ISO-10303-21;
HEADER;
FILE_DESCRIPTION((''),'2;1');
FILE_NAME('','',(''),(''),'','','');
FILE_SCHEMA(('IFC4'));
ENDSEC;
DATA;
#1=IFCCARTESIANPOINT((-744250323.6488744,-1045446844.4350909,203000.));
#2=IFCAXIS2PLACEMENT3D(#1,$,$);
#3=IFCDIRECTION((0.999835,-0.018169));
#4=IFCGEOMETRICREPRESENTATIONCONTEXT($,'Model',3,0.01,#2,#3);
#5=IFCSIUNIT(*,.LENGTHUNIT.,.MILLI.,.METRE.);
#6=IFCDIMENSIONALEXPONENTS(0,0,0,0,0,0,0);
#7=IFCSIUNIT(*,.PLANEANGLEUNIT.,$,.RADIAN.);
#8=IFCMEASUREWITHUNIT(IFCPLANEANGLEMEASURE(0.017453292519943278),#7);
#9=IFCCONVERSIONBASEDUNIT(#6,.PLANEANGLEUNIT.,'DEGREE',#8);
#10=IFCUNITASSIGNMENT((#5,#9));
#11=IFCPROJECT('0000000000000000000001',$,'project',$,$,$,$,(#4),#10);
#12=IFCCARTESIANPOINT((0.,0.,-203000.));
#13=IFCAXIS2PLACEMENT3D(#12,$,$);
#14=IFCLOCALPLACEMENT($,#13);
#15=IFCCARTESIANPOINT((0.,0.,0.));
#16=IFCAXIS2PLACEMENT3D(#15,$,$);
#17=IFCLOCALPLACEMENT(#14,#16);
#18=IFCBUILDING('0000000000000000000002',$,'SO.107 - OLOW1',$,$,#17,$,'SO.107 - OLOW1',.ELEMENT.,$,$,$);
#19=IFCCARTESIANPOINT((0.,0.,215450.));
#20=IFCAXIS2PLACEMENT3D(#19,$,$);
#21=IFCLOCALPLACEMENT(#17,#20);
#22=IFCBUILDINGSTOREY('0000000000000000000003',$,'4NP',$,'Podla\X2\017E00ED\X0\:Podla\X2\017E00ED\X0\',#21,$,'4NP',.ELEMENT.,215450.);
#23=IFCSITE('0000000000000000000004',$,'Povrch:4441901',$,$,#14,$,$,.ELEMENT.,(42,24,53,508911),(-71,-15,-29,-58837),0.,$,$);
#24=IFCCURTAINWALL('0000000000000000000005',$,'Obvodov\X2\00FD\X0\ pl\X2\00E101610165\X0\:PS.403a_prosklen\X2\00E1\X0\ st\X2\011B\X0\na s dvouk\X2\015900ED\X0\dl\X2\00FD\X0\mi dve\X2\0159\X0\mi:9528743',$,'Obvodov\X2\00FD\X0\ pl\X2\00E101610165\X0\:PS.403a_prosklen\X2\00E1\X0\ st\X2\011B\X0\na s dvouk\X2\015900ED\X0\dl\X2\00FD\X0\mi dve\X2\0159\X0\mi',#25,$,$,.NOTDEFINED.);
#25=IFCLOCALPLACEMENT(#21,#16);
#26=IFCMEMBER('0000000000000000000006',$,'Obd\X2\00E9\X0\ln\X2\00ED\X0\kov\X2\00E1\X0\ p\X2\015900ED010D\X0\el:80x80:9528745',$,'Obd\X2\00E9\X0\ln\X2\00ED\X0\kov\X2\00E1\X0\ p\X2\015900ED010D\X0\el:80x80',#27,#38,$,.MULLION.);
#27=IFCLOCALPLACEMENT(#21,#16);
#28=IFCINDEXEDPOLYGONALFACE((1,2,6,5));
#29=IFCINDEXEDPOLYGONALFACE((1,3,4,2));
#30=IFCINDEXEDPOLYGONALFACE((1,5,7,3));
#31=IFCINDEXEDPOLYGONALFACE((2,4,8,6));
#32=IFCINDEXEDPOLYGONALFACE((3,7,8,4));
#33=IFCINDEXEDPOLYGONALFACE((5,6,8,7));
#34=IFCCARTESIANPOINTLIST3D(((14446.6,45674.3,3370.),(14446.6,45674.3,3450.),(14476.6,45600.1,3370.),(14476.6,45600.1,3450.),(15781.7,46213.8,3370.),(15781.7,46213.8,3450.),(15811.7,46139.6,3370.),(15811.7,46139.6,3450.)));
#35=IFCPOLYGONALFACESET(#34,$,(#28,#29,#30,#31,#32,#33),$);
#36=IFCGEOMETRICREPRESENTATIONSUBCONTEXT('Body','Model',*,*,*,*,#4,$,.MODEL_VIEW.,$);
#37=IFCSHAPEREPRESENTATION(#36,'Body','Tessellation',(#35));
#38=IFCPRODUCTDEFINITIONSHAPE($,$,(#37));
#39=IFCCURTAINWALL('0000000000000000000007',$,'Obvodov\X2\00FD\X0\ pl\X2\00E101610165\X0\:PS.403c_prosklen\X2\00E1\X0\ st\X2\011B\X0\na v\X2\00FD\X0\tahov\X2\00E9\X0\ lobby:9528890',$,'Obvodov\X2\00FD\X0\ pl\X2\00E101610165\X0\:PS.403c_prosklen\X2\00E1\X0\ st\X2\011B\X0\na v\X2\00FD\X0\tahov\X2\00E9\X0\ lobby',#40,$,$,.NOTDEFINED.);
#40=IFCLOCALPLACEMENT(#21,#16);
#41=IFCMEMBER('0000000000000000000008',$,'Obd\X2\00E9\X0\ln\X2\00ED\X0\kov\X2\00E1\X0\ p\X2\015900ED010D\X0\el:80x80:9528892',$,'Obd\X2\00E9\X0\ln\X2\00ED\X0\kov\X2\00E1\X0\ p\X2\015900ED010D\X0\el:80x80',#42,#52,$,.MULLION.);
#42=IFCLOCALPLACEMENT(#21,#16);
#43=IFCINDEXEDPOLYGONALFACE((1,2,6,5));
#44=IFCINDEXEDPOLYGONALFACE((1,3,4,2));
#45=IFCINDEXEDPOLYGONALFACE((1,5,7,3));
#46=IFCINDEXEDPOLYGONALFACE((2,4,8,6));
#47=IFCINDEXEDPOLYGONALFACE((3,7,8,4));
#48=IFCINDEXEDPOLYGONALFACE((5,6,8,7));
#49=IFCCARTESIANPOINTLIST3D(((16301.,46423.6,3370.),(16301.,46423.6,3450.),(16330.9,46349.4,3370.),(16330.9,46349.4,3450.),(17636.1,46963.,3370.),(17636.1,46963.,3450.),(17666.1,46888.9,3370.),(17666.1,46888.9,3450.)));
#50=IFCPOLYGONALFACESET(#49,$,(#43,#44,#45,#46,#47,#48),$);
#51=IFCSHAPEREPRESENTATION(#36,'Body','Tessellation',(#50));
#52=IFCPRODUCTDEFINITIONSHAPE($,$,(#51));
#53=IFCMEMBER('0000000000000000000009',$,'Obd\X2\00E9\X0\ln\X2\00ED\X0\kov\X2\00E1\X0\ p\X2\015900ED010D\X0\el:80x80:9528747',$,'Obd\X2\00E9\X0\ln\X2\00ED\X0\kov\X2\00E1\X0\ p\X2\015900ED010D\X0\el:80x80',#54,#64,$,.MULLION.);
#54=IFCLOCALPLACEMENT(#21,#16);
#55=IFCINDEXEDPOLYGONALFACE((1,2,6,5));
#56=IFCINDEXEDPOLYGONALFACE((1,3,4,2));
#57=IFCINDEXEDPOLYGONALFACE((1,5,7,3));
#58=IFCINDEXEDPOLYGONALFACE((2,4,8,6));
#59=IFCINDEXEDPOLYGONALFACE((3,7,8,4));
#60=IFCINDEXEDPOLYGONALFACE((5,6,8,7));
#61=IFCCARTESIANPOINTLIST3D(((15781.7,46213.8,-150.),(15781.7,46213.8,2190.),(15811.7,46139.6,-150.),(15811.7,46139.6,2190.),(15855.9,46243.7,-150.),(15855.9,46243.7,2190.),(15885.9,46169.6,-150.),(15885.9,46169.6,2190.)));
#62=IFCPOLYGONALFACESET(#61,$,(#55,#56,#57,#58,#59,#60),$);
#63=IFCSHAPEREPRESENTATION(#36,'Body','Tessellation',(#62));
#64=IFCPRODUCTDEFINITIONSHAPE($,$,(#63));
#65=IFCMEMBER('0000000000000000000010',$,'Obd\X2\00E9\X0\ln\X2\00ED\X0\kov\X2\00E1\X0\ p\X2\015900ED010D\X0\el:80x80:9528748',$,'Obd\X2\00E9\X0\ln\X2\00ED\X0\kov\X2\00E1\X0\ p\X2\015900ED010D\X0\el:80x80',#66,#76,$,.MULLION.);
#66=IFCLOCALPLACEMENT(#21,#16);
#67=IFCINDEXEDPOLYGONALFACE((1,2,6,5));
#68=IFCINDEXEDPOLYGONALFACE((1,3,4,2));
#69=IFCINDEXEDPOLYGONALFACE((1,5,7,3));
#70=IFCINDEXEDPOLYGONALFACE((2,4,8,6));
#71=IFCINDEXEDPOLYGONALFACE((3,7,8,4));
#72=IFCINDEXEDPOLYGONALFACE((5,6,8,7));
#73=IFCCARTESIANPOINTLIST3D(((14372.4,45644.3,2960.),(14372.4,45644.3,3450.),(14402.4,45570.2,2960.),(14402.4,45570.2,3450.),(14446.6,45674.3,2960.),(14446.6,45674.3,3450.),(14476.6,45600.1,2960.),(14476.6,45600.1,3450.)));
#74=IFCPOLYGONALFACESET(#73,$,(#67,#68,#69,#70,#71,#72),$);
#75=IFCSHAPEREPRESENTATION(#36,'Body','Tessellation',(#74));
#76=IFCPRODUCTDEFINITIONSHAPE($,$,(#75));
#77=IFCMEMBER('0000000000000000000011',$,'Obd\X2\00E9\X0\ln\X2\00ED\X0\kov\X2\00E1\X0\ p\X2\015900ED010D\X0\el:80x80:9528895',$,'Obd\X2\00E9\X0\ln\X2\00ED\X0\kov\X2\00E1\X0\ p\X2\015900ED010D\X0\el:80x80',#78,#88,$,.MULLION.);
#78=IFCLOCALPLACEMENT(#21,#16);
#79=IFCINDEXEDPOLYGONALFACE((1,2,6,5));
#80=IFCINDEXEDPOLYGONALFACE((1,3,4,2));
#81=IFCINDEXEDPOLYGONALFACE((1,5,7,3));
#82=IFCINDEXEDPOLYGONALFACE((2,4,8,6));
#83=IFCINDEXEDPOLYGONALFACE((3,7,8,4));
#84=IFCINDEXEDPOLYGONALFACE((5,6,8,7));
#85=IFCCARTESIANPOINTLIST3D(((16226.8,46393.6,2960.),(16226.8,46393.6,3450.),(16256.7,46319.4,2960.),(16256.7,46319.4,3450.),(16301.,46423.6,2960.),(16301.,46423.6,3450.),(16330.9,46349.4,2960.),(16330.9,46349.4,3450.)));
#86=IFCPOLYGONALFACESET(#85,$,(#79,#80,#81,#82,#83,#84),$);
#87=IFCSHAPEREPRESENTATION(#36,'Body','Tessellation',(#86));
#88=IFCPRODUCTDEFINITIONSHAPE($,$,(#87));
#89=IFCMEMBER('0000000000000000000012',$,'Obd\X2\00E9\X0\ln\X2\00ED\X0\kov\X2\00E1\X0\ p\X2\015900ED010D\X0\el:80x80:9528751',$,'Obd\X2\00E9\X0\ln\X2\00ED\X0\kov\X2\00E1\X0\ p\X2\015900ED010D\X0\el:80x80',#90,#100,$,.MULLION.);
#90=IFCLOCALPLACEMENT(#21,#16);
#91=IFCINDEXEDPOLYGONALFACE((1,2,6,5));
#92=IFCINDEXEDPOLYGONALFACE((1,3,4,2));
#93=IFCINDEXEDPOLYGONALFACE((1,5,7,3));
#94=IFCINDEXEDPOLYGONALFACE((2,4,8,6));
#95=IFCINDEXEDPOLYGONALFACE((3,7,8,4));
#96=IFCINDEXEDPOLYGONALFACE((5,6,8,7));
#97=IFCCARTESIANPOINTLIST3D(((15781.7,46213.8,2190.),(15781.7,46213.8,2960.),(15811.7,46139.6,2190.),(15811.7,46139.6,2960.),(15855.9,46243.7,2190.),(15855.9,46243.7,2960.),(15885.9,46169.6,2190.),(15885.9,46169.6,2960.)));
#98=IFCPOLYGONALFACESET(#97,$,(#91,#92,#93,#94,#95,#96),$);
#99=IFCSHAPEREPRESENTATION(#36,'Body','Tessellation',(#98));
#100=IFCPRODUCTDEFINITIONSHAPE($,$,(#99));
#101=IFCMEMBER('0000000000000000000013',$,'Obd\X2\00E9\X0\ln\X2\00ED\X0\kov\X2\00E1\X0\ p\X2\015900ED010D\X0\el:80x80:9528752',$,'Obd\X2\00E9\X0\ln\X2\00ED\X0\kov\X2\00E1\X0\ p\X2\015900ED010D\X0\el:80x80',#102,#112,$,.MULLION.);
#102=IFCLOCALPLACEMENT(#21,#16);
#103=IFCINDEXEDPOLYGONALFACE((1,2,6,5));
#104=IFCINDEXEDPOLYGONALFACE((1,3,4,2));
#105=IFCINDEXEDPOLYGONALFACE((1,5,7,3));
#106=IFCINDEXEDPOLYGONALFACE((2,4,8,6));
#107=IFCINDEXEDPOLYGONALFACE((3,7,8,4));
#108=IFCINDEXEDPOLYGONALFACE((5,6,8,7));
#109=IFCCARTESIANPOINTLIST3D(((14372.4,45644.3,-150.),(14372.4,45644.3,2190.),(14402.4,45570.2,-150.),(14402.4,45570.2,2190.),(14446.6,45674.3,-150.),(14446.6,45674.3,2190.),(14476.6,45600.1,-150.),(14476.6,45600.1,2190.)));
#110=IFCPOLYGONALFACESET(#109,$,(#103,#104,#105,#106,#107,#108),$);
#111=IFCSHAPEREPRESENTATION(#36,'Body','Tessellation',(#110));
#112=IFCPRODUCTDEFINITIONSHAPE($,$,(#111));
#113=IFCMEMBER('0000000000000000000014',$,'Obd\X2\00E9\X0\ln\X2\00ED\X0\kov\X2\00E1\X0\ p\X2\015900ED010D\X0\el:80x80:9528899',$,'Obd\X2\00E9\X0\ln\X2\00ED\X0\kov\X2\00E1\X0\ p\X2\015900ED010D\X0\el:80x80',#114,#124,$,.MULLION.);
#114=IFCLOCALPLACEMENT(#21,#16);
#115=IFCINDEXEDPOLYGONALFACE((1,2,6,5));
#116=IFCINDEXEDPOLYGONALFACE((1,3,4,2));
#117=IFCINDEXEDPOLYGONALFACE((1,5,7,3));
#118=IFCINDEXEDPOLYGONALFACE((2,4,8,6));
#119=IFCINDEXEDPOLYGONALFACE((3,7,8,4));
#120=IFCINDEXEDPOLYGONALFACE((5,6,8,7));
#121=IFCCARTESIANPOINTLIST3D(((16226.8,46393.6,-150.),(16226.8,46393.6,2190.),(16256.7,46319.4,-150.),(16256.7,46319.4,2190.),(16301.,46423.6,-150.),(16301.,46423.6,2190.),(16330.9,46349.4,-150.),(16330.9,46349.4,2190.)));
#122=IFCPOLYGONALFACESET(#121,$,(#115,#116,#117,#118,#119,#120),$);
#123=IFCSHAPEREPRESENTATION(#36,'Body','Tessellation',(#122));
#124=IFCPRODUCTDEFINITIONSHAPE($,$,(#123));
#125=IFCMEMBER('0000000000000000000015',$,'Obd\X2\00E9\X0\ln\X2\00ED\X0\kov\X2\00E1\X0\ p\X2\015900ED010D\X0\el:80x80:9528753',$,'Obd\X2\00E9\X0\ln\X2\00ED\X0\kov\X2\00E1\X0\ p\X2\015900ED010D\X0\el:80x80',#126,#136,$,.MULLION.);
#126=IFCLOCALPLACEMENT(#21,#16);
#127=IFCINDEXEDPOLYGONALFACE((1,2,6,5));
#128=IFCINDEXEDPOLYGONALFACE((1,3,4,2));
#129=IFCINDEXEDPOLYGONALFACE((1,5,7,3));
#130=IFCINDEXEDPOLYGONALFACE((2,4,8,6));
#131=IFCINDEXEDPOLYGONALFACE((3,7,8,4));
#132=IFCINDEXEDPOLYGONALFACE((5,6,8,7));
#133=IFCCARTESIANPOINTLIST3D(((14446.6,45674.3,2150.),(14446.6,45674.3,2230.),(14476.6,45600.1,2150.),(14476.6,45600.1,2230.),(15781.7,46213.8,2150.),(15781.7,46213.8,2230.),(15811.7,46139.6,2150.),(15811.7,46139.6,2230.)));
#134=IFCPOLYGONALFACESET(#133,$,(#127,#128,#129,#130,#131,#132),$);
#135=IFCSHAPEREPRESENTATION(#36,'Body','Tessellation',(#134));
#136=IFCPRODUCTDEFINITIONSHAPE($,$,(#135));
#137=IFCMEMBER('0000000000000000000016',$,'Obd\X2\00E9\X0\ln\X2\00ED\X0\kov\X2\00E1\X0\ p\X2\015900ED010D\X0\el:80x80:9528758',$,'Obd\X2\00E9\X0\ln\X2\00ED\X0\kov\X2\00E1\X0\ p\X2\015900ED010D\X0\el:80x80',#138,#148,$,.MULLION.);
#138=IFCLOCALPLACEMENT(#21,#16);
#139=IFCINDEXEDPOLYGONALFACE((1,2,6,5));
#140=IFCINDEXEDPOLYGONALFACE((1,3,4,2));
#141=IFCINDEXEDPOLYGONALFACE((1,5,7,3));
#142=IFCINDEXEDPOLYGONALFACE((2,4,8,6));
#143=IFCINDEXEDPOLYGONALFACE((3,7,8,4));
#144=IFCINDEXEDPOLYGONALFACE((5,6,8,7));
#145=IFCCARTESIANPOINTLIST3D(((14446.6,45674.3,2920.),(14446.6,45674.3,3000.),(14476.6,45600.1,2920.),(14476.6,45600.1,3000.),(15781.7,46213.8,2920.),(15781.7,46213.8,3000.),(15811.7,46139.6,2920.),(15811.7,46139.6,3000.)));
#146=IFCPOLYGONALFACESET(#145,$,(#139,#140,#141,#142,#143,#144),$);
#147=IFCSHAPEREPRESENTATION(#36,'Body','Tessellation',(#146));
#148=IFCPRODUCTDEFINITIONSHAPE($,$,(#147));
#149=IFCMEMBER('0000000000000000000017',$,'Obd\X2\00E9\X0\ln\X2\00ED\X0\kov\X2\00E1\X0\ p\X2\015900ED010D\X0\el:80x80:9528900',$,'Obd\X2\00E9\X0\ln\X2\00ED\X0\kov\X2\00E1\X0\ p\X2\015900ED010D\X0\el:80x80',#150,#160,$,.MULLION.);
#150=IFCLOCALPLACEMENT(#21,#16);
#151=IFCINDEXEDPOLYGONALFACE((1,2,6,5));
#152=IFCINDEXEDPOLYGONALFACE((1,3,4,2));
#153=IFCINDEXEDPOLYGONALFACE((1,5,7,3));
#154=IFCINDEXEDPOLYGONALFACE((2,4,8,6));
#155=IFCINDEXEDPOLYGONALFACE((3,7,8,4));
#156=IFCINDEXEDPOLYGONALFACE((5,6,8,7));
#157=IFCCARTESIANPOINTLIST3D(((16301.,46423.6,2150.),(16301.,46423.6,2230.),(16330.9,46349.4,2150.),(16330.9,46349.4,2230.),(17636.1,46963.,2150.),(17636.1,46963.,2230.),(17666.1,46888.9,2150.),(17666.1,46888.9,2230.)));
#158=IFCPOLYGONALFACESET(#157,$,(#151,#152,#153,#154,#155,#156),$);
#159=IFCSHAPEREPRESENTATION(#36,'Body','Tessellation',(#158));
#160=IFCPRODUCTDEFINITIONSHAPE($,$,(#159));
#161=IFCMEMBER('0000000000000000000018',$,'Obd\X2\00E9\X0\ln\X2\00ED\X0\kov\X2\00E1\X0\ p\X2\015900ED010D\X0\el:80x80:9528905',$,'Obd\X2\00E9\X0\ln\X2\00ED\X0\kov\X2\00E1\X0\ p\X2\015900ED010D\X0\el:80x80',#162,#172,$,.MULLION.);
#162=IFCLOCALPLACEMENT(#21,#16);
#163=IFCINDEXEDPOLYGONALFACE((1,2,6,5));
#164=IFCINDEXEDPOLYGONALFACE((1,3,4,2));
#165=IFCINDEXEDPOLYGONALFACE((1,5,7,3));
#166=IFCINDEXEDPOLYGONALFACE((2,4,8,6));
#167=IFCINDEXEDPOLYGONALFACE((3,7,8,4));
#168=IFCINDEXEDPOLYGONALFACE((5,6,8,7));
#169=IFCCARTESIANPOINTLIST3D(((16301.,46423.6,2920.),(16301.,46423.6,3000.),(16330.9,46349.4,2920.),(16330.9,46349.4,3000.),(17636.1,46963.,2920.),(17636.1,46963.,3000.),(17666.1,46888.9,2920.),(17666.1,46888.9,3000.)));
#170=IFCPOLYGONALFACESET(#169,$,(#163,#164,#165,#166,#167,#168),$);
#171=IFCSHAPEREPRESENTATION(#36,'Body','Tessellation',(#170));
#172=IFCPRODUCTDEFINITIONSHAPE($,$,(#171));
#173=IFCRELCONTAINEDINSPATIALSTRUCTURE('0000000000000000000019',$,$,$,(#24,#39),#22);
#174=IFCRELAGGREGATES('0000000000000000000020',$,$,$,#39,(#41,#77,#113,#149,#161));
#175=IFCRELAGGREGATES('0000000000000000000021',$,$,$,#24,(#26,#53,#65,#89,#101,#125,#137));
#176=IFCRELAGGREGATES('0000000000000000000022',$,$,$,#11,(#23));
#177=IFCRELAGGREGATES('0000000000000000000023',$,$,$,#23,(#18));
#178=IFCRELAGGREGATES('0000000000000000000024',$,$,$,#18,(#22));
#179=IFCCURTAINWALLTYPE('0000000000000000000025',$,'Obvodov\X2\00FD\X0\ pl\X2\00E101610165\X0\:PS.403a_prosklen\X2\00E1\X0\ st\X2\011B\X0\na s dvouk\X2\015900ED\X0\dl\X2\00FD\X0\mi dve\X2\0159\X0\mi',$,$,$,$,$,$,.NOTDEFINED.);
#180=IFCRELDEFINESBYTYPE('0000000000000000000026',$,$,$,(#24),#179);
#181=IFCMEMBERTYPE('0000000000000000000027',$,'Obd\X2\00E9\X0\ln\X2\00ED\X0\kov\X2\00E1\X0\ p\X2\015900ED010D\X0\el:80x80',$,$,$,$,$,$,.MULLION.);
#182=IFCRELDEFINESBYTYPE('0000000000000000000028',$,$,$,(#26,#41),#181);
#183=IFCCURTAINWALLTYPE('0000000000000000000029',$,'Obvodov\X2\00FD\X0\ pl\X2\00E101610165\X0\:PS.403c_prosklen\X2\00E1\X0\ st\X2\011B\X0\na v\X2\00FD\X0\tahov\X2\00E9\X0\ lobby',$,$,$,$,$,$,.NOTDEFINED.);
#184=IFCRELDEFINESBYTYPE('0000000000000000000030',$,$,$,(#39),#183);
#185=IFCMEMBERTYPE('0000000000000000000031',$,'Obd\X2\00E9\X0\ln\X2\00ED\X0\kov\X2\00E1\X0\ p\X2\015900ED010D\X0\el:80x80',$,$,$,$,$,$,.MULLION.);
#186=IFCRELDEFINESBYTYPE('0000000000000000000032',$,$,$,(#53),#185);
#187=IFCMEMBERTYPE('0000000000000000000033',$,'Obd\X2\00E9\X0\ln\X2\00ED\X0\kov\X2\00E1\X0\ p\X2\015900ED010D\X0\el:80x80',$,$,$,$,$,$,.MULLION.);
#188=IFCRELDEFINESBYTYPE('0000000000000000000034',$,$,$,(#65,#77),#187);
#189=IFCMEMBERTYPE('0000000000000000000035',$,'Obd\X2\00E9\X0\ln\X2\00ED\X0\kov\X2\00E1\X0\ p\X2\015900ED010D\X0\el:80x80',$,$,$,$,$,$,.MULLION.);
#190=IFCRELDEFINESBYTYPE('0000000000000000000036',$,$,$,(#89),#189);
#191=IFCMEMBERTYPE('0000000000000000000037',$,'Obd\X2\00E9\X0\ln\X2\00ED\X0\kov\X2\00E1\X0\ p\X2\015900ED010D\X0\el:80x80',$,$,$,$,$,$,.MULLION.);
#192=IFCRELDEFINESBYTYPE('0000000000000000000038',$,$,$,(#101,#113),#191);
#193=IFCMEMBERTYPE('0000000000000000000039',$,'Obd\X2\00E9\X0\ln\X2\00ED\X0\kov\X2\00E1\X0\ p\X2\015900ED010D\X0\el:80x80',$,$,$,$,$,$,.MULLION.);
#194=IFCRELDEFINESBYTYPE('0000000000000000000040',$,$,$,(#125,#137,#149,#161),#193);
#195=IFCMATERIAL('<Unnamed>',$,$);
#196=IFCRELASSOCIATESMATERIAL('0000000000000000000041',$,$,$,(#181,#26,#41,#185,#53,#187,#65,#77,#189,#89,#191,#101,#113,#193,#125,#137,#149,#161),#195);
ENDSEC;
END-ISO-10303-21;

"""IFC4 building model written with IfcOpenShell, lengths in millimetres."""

from ifc_helpers import new_model, entity, si_unit, converted_unit, direction, frame, origin, place, context, subcontext, project, spatial, indexed_curve, outline, extrude, source, transform, mapped, material, type_object, type_shapes, element, aggregate, save


model = new_model("IFC4")

# Units and contexts
model_context = context("Model", 3, precision=0.01, world=frame((-744250323.6488744, -1045446844.4350909, 203000.0)), true_north=direction((0.999835, -0.018169)))
body_context = subcontext(model_context, "Body", "Model", "MODEL_VIEW")
ifc_project = project(units=[si_unit("LENGTHUNIT", "METRE", prefix="MILLI"), converted_unit("PLANEANGLEUNIT", "DEGREE", entity("IfcPlaneAngleMeasure", 0.017453292519943278), si_unit("PLANEANGLEUNIT", "RADIAN"), dimensions=[0, 0, 0, 0, 0, 0, 0])], contexts=[model_context])

# Site, building, storey
site_placement = place(None, frame((0.0, 0.0, -203000.0)))
site = spatial("IfcSite", under=ifc_project, at=site_placement, Name="Povrch:4441901", CompositionType="ELEMENT", RefLatitude=(42, 24, 53, 508911), RefLongitude=(-71, -15, -29, -58837), RefElevation=0.0)
building_placement = place(site_placement, origin())
building = spatial("IfcBuilding", under=site, at=building_placement, Name="SO.107 - OLOW1", LongName="SO.107 - OLOW1", CompositionType="ELEMENT")
storey_placement = place(building_placement, frame((0.0, 0.0, 215450.0)))
storey = spatial("IfcBuildingStorey", under=building, at=storey_placement, Name="4NP", ObjectType="Podlaží:Podlaží", LongName="4NP", CompositionType="ELEMENT", Elevation=215450.0)

# Curtain walls, members
curtain_wall_type_1 = type_object("IfcCurtainWallType", Name="Obvodový plášť:PS.403a_prosklená stěna s dvoukřídlými dveřmi", PredefinedType="NOTDEFINED")
curtain_wall_1_placement = place(storey_placement, frame((0.0, 0.0, -215450.0)))
curtain_wall_1 = element("IfcCurtainWall", 1, at=curtain_wall_1_placement, inside=storey, type_object=curtain_wall_type_1, Name="Obvodový plášť:PS.403a_prosklená stěna s dvoukřídlými dveřmi:9528743", ObjectType="Obvodový plášť:PS.403a_prosklená stěna s dvoukřídlými dveřmi", PredefinedType="NOTDEFINED")
ifc_material_1 = material(Name="<Unnamed>")
member_type_1 = type_object("IfcMemberType", Name="Obdélníková příčel:80x80", PredefinedType="MULLION", material=ifc_material_1)
shared_shape_1 = source(origin(), body_context, "Body", "SweptSolid", [
    extrude(outline(indexed_curve([(-40.0, -40.0), (40.0, -40.0), (40.0, 40.0), (-40.0, 40.0), (-40.0, -40.0)], self_intersect=False)), frame((-40.0, 0.0, -1440.0), z_axis=(0.0, 0.0, 1.0), x_axis=(-1.0, 0.0, 0.0)), (0.0, 0.0, 1.0), 1440.0),
])
type_shapes(member_type_1, [shared_shape_1])
member_1_placement = place(curtain_wall_1_placement, frame((15796.7, 46176.7, 218900.0), z_axis=(0.927176, 0.374626, 0.0), x_axis=(0.0, 0.0, 1.0)))
member_1 = element("IfcMember", 2, at=member_1_placement, type_object=member_type_1, material=ifc_material_1, Name="Obdélníková příčel:80x80:9528745", ObjectType="Obdélníková příčel:80x80", PredefinedType="MULLION", context=body_context, shape_type="MappedRepresentation", body=[
    mapped(shared_shape_1, transform((0.0, 0.0, 0.0), scale=1.0)),
])
curtain_wall_type_2 = type_object("IfcCurtainWallType", Name="Obvodový plášť:PS.403c_prosklená stěna výtahové lobby", PredefinedType="NOTDEFINED")
curtain_wall_2_placement = place(storey_placement, frame((0.0, 0.0, -215450.0)))
curtain_wall_2 = element("IfcCurtainWall", 3, at=curtain_wall_2_placement, inside=storey, type_object=curtain_wall_type_2, Name="Obvodový plášť:PS.403c_prosklená stěna výtahové lobby:9528890", ObjectType="Obvodový plášť:PS.403c_prosklená stěna výtahové lobby", PredefinedType="NOTDEFINED")
member_2_placement = place(curtain_wall_2_placement, frame((17651.1, 46925.9, 218900.0), z_axis=(0.927176, 0.374626, 0.0), x_axis=(0.0, 0.0, 1.0)))
member_2 = element("IfcMember", 4, at=member_2_placement, type_object=member_type_1, material=ifc_material_1, Name="Obdélníková příčel:80x80:9528892", ObjectType="Obdélníková příčel:80x80", PredefinedType="MULLION", context=body_context, shape_type="MappedRepresentation", body=[
    mapped(shared_shape_1, transform((0.0, 0.0, 0.0), scale=1.0)),
])

# Members
member_type_2 = type_object("IfcMemberType", Name="Obdélníková příčel:80x80", PredefinedType="MULLION", material=ifc_material_1)
shared_shape_2 = source(origin(), body_context, "Body", "SweptSolid", [
    extrude(outline(indexed_curve([(-40.0, -40.0), (40.0, -40.0), (40.0, 40.0), (-40.0, 40.0), (-40.0, -40.0)], self_intersect=False)), frame((-40.0, 0.0, -2340.0), z_axis=(0.0, 0.0, 1.0), x_axis=(-1.0, 0.0, 0.0)), (0.0, 0.0, 1.0), 2340.0),
])
type_shapes(member_type_2, [shared_shape_2])
member_3_placement = place(curtain_wall_1_placement, frame((15870.9, 46206.7, 215300.0), z_axis=(0.0, 0.0, -1.0), x_axis=(0.927176, 0.374626, 0.0)))
member_3 = element("IfcMember", 5, at=member_3_placement, type_object=member_type_2, material=ifc_material_1, Name="Obdélníková příčel:80x80:9528747", ObjectType="Obdélníková příčel:80x80", PredefinedType="MULLION", context=body_context, shape_type="MappedRepresentation", body=[
    mapped(shared_shape_2, transform((0.0, 0.0, 0.0), scale=1.0)),
])
member_type_3 = type_object("IfcMemberType", Name="Obdélníková příčel:80x80", PredefinedType="MULLION", material=ifc_material_1)
shared_shape_3 = source(origin(), body_context, "Body", "SweptSolid", [
    extrude(outline(indexed_curve([(-40.0, -40.0), (40.0, -40.0), (40.0, 40.0), (-40.0, 40.0), (-40.0, -40.0)], self_intersect=False)), frame((-40.0, 0.0, -490.0), z_axis=(0.0, 0.0, 1.0), x_axis=(-1.0, 0.0, 0.0)), (0.0, 0.0, 1.0), 490.0),
])
type_shapes(member_type_3, [shared_shape_3])
member_4_placement = place(curtain_wall_1_placement, frame((14387.4, 45607.3, 218900.0), z_axis=(0.0, 0.0, 1.0), x_axis=(-0.927176, -0.374626, 0.0)))
member_4 = element("IfcMember", 6, at=member_4_placement, type_object=member_type_3, material=ifc_material_1, Name="Obdélníková příčel:80x80:9528748", ObjectType="Obdélníková příčel:80x80", PredefinedType="MULLION", context=body_context, shape_type="MappedRepresentation", body=[
    mapped(shared_shape_3, transform((0.0, 0.0, 0.0), scale=1.0)),
])
member_5_placement = place(curtain_wall_2_placement, frame((16241.8, 46356.5, 218900.0), z_axis=(0.0, 0.0, 1.0), x_axis=(-0.927176, -0.374626, 0.0)))
member_5 = element("IfcMember", 7, at=member_5_placement, type_object=member_type_3, material=ifc_material_1, Name="Obdélníková příčel:80x80:9528895", ObjectType="Obdélníková příčel:80x80", PredefinedType="MULLION", context=body_context, shape_type="MappedRepresentation", body=[
    mapped(shared_shape_3, transform((0.0, 0.0, 0.0), scale=1.0)),
])
member_type_4 = type_object("IfcMemberType", Name="Obdélníková příčel:80x80", PredefinedType="MULLION", material=ifc_material_1)
shared_shape_4 = source(origin(), body_context, "Body", "SweptSolid", [
    extrude(outline(indexed_curve([(-40.0, -40.0), (40.0, -40.0), (40.0, 40.0), (-40.0, 40.0), (-40.0, -40.0)], self_intersect=False)), frame((-40.0, 0.0, -770.0), z_axis=(0.0, 0.0, 1.0), x_axis=(-1.0, 0.0, 0.0)), (0.0, 0.0, 1.0), 770.0),
])
type_shapes(member_type_4, [shared_shape_4])
member_6_placement = place(curtain_wall_1_placement, frame((15870.9, 46206.7, 217640.0), z_axis=(0.0, 0.0, -1.0), x_axis=(0.927176, 0.374626, 0.0)))
member_6 = element("IfcMember", 8, at=member_6_placement, type_object=member_type_4, material=ifc_material_1, Name="Obdélníková příčel:80x80:9528751", ObjectType="Obdélníková příčel:80x80", PredefinedType="MULLION", context=body_context, shape_type="MappedRepresentation", body=[
    mapped(shared_shape_4, transform((0.0, 0.0, 0.0), scale=1.0)),
])
member_type_5 = type_object("IfcMemberType", Name="Obdélníková příčel:80x80", PredefinedType="MULLION", material=ifc_material_1)
shared_shape_5 = source(origin(), body_context, "Body", "SweptSolid", [
    extrude(outline(indexed_curve([(-40.0, -40.0), (40.0, -40.0), (40.0, 40.0), (-40.0, 40.0), (-40.0, -40.0)], self_intersect=False)), frame((-40.0, 0.0, -2340.0), z_axis=(0.0, 0.0, 1.0), x_axis=(-1.0, 0.0, 0.0)), (0.0, 0.0, 1.0), 2340.0),
])
type_shapes(member_type_5, [shared_shape_5])
member_7_placement = place(curtain_wall_1_placement, frame((14387.4, 45607.3, 217640.0), z_axis=(0.0, 0.0, 1.0), x_axis=(-0.927176, -0.374626, 0.0)))
member_7 = element("IfcMember", 9, at=member_7_placement, type_object=member_type_5, material=ifc_material_1, Name="Obdélníková příčel:80x80:9528752", ObjectType="Obdélníková příčel:80x80", PredefinedType="MULLION", context=body_context, shape_type="MappedRepresentation", body=[
    mapped(shared_shape_5, transform((0.0, 0.0, 0.0), scale=1.0)),
])
member_8_placement = place(curtain_wall_2_placement, frame((16241.8, 46356.5, 217640.0), z_axis=(0.0, 0.0, 1.0), x_axis=(-0.927176, -0.374626, 0.0)))
member_8 = element("IfcMember", 10, at=member_8_placement, type_object=member_type_5, material=ifc_material_1, Name="Obdélníková příčel:80x80:9528899", ObjectType="Obdélníková příčel:80x80", PredefinedType="MULLION", context=body_context, shape_type="MappedRepresentation", body=[
    mapped(shared_shape_5, transform((0.0, 0.0, 0.0), scale=1.0)),
])
member_type_6 = type_object("IfcMemberType", Name="Obdélníková příčel:80x80", PredefinedType="MULLION", material=ifc_material_1)
shared_shape_6 = source(origin(), body_context, "Body", "SweptSolid", [
    extrude(outline(indexed_curve([(-40.0, -40.0), (40.0, -40.0), (40.0, 40.0), (-40.0, 40.0), (-40.0, -40.0)], self_intersect=False)), frame((0.0, 0.0, -1440.0), z_axis=(0.0, 0.0, 1.0), x_axis=(-1.0, 0.0, 0.0)), (0.0, 0.0, 1.0), 1440.0),
])
type_shapes(member_type_6, [shared_shape_6])
member_9_placement = place(curtain_wall_1_placement, frame((15796.7, 46176.7, 217640.0), z_axis=(0.927176, 0.374626, 0.0), x_axis=(0.0, 0.0, 1.0)))
member_9 = element("IfcMember", 11, at=member_9_placement, type_object=member_type_6, material=ifc_material_1, Name="Obdélníková příčel:80x80:9528753", ObjectType="Obdélníková příčel:80x80", PredefinedType="MULLION", context=body_context, shape_type="MappedRepresentation", body=[
    mapped(shared_shape_6, transform((0.0, 0.0, 0.0), scale=1.0)),
])
member_10_placement = place(curtain_wall_1_placement, frame((15796.7, 46176.7, 218410.0), z_axis=(0.927176, 0.374626, 0.0), x_axis=(0.0, 0.0, 1.0)))
member_10 = element("IfcMember", 12, at=member_10_placement, type_object=member_type_6, material=ifc_material_1, Name="Obdélníková příčel:80x80:9528758", ObjectType="Obdélníková příčel:80x80", PredefinedType="MULLION", context=body_context, shape_type="MappedRepresentation", body=[
    mapped(shared_shape_6, transform((0.0, 0.0, 0.0), scale=1.0)),
])
member_11_placement = place(curtain_wall_2_placement, frame((17651.1, 46925.9, 217640.0), z_axis=(0.927176, 0.374626, 0.0), x_axis=(0.0, 0.0, 1.0)))
member_11 = element("IfcMember", 13, at=member_11_placement, type_object=member_type_6, material=ifc_material_1, Name="Obdélníková příčel:80x80:9528900", ObjectType="Obdélníková příčel:80x80", PredefinedType="MULLION", context=body_context, shape_type="MappedRepresentation", body=[
    mapped(shared_shape_6, transform((0.0, 0.0, 0.0), scale=1.0)),
])
member_12_placement = place(curtain_wall_2_placement, frame((17651.1, 46925.9, 218410.0), z_axis=(0.927176, 0.374626, 0.0), x_axis=(0.0, 0.0, 1.0)))
member_12 = element("IfcMember", 14, at=member_12_placement, type_object=member_type_6, material=ifc_material_1, Name="Obdélníková příčel:80x80:9528905", ObjectType="Obdélníková příčel:80x80", PredefinedType="MULLION", context=body_context, shape_type="MappedRepresentation", body=[
    mapped(shared_shape_6, transform((0.0, 0.0, 0.0), scale=1.0)),
])

aggregate(curtain_wall_2, [member_2, member_5, member_8, member_11, member_12])

aggregate(curtain_wall_1, [member_1, member_3, member_4, member_6, member_7, member_9, member_10])

save(model, "model.ifc")
